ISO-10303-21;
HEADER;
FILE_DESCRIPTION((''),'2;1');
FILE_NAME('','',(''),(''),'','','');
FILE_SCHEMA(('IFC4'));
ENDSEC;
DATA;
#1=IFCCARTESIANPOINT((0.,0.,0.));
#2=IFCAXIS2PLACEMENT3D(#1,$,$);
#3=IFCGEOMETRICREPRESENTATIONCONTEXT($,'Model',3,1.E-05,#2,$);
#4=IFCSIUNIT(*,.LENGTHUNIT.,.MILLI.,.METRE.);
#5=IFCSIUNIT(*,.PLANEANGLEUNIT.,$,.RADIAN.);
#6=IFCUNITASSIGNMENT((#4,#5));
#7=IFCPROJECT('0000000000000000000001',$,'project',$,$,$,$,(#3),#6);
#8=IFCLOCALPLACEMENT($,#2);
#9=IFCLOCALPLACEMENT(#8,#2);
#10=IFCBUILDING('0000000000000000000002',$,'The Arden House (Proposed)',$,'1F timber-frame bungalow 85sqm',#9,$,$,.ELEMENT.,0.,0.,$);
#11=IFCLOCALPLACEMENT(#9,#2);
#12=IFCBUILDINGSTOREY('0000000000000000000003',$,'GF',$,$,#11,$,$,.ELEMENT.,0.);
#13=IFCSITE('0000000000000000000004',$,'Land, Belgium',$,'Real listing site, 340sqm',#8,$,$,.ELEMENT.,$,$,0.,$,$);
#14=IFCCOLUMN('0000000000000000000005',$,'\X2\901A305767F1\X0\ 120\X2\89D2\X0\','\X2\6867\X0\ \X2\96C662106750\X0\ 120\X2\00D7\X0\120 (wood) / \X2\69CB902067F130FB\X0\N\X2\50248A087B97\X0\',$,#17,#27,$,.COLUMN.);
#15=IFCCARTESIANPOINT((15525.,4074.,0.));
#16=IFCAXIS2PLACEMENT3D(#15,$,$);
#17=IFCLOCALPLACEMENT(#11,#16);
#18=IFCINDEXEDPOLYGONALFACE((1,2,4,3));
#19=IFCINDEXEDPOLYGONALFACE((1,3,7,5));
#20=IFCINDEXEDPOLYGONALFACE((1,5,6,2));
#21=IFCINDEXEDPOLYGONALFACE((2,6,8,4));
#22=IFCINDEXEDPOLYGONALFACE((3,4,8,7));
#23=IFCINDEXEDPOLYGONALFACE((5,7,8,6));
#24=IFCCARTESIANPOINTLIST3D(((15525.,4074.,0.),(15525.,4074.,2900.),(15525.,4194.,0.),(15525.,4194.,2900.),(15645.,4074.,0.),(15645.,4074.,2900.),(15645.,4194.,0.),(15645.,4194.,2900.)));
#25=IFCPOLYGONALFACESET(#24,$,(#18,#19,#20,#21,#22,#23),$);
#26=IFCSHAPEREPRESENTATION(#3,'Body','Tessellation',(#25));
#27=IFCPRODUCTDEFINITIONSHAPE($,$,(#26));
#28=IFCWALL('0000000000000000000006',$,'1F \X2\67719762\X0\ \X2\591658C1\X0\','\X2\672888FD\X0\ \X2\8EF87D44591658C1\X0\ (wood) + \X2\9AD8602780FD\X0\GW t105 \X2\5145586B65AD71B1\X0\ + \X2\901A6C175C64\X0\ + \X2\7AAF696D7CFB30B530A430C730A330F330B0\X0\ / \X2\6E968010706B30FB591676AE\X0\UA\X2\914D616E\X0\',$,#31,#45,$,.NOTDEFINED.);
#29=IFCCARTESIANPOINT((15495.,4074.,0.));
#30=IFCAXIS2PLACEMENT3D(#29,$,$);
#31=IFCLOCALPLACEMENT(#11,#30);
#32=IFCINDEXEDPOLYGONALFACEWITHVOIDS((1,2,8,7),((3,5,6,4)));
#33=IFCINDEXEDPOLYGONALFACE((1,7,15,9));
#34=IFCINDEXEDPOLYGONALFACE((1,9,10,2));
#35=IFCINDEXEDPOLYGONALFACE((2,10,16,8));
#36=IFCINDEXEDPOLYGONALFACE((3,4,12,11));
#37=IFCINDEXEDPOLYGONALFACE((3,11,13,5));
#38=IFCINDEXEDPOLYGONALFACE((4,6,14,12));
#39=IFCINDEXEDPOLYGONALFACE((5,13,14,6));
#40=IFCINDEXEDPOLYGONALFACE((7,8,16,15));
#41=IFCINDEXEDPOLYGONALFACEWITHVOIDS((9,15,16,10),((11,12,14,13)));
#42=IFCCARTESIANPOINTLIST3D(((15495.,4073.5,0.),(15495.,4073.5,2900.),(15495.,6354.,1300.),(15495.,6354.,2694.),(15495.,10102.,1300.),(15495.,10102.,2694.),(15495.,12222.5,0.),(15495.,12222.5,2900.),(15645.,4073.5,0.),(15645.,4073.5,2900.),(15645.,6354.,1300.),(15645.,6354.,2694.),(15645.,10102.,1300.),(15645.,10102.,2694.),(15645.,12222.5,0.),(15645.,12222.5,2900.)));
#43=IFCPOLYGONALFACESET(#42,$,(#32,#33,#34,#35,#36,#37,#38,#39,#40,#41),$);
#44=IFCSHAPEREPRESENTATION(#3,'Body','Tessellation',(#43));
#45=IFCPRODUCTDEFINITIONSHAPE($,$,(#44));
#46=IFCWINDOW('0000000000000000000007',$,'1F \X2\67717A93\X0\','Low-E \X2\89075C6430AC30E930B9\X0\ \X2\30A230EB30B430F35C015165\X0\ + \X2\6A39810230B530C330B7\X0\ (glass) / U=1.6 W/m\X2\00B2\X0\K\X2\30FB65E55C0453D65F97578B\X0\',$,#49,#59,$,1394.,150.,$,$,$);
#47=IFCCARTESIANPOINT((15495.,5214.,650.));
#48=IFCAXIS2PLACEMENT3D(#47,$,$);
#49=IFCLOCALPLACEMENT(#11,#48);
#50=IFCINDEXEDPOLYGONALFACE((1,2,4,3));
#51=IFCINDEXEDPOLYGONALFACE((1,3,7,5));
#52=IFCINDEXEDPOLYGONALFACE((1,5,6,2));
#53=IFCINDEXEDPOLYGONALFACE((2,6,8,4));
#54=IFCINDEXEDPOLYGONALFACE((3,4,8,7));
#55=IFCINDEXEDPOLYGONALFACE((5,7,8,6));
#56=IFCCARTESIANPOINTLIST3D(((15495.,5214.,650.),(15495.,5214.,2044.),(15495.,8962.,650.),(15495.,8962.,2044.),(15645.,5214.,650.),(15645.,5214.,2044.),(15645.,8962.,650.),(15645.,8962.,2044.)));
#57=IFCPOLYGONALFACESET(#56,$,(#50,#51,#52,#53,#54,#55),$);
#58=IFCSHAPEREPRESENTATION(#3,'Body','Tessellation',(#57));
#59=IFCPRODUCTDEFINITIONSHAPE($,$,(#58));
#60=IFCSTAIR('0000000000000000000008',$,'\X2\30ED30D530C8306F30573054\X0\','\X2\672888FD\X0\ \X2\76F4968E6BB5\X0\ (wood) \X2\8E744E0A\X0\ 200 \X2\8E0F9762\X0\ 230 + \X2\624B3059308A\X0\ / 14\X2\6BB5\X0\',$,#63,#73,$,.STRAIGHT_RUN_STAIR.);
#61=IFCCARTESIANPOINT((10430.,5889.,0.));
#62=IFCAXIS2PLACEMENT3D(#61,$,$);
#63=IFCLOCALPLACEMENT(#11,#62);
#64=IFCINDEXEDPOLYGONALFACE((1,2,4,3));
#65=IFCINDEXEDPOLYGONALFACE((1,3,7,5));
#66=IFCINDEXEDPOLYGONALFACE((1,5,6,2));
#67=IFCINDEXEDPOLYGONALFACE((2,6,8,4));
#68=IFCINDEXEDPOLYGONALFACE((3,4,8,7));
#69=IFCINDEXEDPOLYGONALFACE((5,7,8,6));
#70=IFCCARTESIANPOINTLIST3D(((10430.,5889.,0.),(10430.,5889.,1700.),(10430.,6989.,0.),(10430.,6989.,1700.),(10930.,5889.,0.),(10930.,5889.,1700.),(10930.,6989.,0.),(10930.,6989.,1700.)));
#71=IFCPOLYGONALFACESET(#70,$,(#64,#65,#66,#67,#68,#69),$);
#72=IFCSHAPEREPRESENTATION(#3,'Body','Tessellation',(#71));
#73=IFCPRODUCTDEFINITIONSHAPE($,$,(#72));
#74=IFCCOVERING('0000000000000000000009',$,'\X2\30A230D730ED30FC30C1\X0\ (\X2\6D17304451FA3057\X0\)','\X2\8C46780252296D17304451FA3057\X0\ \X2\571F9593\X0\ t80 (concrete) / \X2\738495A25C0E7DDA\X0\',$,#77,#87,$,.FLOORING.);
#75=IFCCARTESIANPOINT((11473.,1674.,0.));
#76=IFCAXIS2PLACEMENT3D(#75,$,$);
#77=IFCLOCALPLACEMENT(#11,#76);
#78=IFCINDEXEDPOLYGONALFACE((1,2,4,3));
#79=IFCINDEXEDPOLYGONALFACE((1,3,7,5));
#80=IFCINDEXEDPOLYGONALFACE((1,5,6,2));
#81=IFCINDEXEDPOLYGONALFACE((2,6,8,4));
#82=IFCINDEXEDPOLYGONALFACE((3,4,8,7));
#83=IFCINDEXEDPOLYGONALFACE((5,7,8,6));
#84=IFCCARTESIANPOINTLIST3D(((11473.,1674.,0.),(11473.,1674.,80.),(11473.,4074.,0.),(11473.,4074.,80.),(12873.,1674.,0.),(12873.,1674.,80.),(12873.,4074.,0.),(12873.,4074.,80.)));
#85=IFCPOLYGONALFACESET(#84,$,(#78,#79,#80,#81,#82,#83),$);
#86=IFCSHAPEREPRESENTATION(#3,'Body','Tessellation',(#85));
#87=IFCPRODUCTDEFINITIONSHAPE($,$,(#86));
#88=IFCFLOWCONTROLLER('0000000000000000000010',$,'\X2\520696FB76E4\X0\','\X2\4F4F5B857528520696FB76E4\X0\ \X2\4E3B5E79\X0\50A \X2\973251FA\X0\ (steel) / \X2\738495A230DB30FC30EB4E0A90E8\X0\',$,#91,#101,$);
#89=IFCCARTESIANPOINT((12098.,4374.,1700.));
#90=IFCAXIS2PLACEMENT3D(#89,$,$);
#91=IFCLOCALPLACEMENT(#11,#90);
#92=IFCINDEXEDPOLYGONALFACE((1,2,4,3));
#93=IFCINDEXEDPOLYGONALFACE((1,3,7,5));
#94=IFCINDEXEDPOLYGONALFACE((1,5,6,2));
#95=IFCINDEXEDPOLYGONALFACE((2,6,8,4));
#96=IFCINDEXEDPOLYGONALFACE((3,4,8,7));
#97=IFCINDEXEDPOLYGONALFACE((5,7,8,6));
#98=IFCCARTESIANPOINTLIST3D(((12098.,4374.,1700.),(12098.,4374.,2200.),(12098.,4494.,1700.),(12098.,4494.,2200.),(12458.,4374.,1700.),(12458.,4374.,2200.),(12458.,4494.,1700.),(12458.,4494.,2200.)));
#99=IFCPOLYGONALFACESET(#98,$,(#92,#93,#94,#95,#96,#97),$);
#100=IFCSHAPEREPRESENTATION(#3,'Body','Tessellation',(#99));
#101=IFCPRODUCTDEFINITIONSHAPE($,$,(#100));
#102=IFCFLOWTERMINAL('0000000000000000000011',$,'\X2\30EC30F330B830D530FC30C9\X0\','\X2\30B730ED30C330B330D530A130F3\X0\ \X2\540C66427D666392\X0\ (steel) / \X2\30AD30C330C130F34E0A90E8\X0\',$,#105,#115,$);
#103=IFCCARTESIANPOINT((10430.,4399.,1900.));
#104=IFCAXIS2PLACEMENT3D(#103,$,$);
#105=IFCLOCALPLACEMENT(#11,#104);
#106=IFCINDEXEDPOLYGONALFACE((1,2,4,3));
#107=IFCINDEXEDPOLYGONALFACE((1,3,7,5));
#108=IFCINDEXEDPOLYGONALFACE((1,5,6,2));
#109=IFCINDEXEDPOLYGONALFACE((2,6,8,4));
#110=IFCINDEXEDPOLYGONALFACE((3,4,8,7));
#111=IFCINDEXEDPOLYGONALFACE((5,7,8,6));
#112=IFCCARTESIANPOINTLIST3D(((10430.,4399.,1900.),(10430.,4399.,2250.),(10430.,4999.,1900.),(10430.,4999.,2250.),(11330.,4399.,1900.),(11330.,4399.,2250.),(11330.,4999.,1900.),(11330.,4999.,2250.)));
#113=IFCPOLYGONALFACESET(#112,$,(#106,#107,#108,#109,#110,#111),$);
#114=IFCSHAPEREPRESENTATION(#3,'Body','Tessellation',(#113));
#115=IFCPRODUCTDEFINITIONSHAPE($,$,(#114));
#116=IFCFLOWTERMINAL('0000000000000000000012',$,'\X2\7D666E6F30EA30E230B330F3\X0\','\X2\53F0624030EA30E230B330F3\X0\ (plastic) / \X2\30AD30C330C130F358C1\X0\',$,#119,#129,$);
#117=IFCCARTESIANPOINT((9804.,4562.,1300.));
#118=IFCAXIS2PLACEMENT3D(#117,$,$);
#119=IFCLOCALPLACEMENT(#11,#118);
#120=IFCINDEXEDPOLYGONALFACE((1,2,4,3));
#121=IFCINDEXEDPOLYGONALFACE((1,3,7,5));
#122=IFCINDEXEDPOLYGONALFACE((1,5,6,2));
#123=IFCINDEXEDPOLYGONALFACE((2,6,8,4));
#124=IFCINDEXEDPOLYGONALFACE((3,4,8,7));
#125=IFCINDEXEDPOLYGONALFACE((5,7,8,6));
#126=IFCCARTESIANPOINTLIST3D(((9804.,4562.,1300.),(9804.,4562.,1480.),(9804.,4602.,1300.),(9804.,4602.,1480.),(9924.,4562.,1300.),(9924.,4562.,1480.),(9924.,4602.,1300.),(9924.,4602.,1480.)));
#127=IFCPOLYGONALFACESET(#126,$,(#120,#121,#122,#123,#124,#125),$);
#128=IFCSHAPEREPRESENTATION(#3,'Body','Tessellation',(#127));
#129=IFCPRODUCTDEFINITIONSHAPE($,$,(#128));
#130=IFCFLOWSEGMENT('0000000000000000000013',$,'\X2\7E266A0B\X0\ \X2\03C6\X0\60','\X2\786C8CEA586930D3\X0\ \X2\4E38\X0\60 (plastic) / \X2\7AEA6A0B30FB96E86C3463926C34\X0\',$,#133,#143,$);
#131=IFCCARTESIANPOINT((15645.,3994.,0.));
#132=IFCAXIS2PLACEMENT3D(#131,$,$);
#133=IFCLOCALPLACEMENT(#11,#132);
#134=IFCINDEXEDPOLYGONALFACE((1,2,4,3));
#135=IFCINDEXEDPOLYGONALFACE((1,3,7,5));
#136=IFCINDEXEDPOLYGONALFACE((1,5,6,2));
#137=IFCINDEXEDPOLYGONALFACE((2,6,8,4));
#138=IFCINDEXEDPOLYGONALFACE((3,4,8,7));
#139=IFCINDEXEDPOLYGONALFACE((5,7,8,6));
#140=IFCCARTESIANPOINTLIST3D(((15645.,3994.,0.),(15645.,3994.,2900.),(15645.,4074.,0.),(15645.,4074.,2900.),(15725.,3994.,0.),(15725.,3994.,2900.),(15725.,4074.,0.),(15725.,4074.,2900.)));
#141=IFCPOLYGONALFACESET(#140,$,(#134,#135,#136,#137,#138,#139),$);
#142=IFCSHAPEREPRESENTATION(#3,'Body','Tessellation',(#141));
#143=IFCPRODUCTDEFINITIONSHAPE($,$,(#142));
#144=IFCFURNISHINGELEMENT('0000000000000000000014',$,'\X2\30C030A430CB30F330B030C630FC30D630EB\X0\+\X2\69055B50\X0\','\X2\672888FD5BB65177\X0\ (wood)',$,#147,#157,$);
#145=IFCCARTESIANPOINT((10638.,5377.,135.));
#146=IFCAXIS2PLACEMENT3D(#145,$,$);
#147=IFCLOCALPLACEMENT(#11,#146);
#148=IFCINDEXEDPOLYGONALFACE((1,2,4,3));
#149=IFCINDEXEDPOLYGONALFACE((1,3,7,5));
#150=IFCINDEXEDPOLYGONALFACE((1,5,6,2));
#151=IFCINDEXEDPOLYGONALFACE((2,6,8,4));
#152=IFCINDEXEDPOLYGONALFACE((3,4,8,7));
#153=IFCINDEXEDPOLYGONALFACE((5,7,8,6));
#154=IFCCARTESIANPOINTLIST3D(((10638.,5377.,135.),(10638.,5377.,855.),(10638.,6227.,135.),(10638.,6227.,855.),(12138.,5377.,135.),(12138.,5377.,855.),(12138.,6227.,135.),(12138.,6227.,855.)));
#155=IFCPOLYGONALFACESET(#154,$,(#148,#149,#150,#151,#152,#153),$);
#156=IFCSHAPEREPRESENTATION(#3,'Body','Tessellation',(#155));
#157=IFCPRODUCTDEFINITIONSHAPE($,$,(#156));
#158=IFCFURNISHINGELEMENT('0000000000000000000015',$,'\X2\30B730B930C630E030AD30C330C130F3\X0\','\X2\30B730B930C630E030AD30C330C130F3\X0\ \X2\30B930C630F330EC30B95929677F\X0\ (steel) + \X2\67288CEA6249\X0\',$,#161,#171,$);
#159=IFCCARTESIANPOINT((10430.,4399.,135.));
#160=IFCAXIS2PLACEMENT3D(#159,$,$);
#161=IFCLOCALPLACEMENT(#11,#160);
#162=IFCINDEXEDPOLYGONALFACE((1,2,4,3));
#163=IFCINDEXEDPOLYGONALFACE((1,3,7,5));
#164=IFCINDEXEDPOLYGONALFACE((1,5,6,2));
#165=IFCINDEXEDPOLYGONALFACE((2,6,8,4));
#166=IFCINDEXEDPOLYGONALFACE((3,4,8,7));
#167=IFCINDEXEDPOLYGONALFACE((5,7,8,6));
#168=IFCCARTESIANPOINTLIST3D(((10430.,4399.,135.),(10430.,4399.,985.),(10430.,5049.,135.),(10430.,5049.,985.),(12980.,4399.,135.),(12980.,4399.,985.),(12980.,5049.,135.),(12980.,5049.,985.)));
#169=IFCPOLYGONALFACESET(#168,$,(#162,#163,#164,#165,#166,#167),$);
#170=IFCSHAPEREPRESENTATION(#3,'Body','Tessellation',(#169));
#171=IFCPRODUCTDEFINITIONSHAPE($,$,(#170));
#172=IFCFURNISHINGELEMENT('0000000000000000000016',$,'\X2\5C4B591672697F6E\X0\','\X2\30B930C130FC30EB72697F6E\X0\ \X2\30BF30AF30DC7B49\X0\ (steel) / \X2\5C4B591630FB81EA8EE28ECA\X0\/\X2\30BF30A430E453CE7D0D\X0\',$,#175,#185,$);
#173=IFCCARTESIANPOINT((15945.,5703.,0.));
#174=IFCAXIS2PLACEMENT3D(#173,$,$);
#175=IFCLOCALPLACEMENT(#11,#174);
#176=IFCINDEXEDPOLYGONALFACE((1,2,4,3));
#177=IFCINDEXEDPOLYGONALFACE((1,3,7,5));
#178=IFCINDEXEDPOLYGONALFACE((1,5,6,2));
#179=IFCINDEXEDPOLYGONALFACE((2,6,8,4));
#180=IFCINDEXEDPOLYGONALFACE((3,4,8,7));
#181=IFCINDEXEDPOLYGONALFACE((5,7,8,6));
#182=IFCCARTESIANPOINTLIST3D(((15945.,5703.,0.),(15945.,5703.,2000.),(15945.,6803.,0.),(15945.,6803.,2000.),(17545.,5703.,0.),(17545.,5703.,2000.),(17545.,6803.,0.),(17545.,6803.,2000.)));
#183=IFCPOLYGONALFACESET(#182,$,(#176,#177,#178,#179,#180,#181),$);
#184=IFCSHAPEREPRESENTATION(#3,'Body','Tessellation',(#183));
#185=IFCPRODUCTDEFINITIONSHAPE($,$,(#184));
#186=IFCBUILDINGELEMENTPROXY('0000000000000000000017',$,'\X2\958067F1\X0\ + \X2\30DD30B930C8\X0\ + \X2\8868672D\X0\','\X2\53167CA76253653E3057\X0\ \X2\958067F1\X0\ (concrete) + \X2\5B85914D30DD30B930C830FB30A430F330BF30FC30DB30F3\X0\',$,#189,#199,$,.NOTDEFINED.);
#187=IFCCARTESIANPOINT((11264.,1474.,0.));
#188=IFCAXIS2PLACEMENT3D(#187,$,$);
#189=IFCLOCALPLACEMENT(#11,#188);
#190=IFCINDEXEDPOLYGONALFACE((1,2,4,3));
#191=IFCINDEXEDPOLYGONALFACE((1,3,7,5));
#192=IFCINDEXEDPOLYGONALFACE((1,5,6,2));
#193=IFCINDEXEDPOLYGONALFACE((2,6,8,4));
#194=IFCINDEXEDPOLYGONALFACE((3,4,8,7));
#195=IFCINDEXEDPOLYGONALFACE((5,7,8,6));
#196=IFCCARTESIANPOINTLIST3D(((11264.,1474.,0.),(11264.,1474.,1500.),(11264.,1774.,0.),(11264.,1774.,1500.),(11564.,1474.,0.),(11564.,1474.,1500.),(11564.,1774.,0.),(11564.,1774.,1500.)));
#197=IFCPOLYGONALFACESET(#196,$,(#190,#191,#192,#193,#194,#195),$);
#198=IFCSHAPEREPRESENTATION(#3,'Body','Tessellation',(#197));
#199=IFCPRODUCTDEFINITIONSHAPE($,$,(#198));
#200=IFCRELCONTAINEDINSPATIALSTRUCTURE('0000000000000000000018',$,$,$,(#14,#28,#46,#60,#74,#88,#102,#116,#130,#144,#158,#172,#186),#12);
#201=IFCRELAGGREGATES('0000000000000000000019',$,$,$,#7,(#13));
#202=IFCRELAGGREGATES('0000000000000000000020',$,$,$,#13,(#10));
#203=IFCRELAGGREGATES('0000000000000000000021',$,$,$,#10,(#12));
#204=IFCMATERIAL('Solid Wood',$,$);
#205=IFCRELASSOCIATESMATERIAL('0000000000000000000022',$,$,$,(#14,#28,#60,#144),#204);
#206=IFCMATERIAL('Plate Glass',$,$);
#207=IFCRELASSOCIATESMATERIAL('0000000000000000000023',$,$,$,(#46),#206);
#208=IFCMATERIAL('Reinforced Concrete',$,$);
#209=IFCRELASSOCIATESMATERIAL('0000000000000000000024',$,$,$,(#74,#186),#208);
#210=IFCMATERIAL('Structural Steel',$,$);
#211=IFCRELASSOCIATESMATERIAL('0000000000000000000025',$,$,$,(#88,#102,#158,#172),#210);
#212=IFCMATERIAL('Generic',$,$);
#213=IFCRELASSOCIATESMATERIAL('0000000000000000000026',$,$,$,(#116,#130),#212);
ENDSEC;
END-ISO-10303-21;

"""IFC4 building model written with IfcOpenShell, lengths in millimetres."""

from ifc_helpers import new_model, si_unit, frame, frame_2d, origin, place, context, project, spatial, rectangle, extrude, material, element, fill, save


model = new_model("IFC4")

# Units and contexts
model_context = context("Model", 3, precision=1e-05, world=origin())
ifc_project = project(units=[si_unit("LENGTHUNIT", "METRE", prefix="MILLI"), si_unit("PLANEANGLEUNIT", "RADIAN")], contexts=[model_context])

# Site, building, storey
site_placement = place(None, origin())
site = spatial("IfcSite", under=ifc_project, at=site_placement, Name="Land, Belgium", ObjectType="Real listing site, 340sqm", CompositionType="ELEMENT", RefElevation=0.0)
building_placement = place(site_placement, origin())
building = spatial("IfcBuilding", under=site, at=building_placement, Name="The Arden House (Proposed)", ObjectType="1F timber-frame bungalow 85sqm", CompositionType="ELEMENT", ElevationOfRefHeight=0.0, ElevationOfTerrain=0.0)
storey_placement = place(building_placement, origin())
storey = spatial("IfcBuildingStorey", under=building, at=storey_placement, Name="GF", CompositionType="ELEMENT", Elevation=0.0)

# Column
ifc_material_1 = material(Name="Solid Wood")
column_1_placement = place(storey_placement, frame((15525.0, 4074.0, 0.0)))
element("IfcColumn", 1, at=column_1_placement, inside=storey, material=ifc_material_1, Name="通し柱 120角", Description="桧 集成材 120×120 (wood) / 構造柱・N値計算", PredefinedType="COLUMN", context=model_context, shape_type="SweptSolid", body=[
    extrude(rectangle(XDim=120.0, YDim=120.0, at=frame_2d((60.0, 60.0))), frame((15525.0, 4074.0, 0.0)), (0.0, 0.0, 1.0), 2900.0),
])

# Wall, opening, window
wall_1_placement = place(storey_placement, frame((15495.0, 4074.0, 0.0)))
wall_1 = element("IfcWall", 2, at=wall_1_placement, inside=storey, material=ifc_material_1, Name="1F 東面 外壁", Description="木製 軸組外壁 (wood) + 高性能GW t105 充填断熱 + 通気層 + 窯業系サイディング / 準耐火・外皮UA配慮", PredefinedType="NOTDEFINED", context=model_context, shape_type="SweptSolid", body=[
    extrude(rectangle(XDim=150.0, YDim=8149.0, at=frame_2d((75.0, 4074.0))), frame((15495.0, 4074.0, 0.0)), (0.0, 0.0, 1.0), 2900.0),
])
opening_placement = place(storey_placement, frame((15495.0, 5214.0, 650.0)))
opening = element("IfcOpeningElement", 3, at=opening_placement, cuts=wall_1, PredefinedType="NOTDEFINED", context=model_context, shape_type="SweptSolid", body=[
    extrude(rectangle(XDim=150.0, YDim=3748.0, at=frame_2d((75.0, 1874.0))), frame((15495.0, 5214.0, 650.0)), (0.0, 0.0, 1.0), 1394.0),
])
ifc_material_2 = material(Name="Plate Glass")
window_placement = place(storey_placement, frame((15495.0, 5214.0, 650.0)))
window = element("IfcWindow", 4, at=window_placement, inside=storey, material=ifc_material_2, Name="1F 東窓", Description="Low-E 複層ガラス アルゴン封入 + 樹脂サッシ (glass) / U=1.6 W/m²K・日射取得型", OverallHeight=1394.0, OverallWidth=150.0, context=model_context, shape_type="SweptSolid", body=[
    extrude(rectangle(XDim=150.0, YDim=3748.0, at=frame_2d((75.0, 1874.0))), frame((15495.0, 5214.0, 650.0)), (0.0, 0.0, 1.0), 1394.0),
])
fill(opening, window)

# Stair
stair_placement = place(storey_placement, frame((10430.0, 5889.0, 0.0)))
element("IfcStair", 5, at=stair_placement, inside=storey, material=ifc_material_1, Name="ロフトはしご", Description="木製 直階段 (wood) 蹴上 200 踏面 230 + 手すり / 14段", PredefinedType="STRAIGHT_RUN_STAIR", context=model_context, shape_type="SweptSolid", body=[
    extrude(rectangle(XDim=500.0, YDim=1100.0, at=frame_2d((250.0, 550.0))), frame((10430.0, 5889.0, 0.0)), (0.0, 0.0, 1.0), 1700.0),
])

# Covering
ifc_material_3 = material(Name="Reinforced Concrete")
covering_placement = place(storey_placement, frame((11473.0, 1674.0, 0.0)))
element("IfcCovering", 6, at=covering_placement, inside=storey, material=ifc_material_3, Name="アプローチ (洗い出し)", Description="豆砂利洗い出し 土間 t80 (concrete) / 玄関導線", PredefinedType="FLOORING", context=model_context, shape_type="SweptSolid", body=[
    extrude(rectangle(XDim=1400.0, YDim=2400.0, at=frame_2d((700.0, 1200.0))), frame((11473.0, 1674.0, 0.0)), (0.0, 0.0, 1.0), 80.0),
])

# Flow controller
ifc_material_4 = material(Name="Structural Steel")
flow_controller_placement = place(storey_placement, frame((12098.0, 4374.0, 1700.0)))
element("IfcFlowController", 7, at=flow_controller_placement, inside=storey, material=ifc_material_4, Name="分電盤", Description="住宅用分電盤 主幹50A 露出 (steel) / 玄関ホール上部", context=model_context, shape_type="SweptSolid", body=[
    extrude(rectangle(XDim=360.0, YDim=120.0, at=frame_2d((180.0, 60.0))), frame((12098.0, 4374.0, 1700.0)), (0.0, 0.0, 1.0), 500.0),
])

# Flow terminals
flow_terminal_1_placement = place(storey_placement, frame((10430.0, 4399.0, 1900.0)))
element("IfcFlowTerminal", 8, at=flow_terminal_1_placement, inside=storey, material=ifc_material_4, Name="レンジフード", Description="シロッコファン 同時給排 (steel) / キッチン上部", context=model_context, shape_type="SweptSolid", body=[
    extrude(rectangle(XDim=900.0, YDim=600.0, at=frame_2d((450.0, 300.0))), frame((10430.0, 4399.0, 1900.0)), (0.0, 0.0, 1.0), 350.0),
])
ifc_material_5 = material(Name="Generic")
flow_terminal_2_placement = place(storey_placement, frame((9804.0, 4562.0, 1300.0)))
element("IfcFlowTerminal", 9, at=flow_terminal_2_placement, inside=storey, material=ifc_material_5, Name="給湯リモコン", Description="台所リモコン (plastic) / キッチン壁", context=model_context, shape_type="SweptSolid", body=[
    extrude(rectangle(XDim=120.0, YDim=40.0, at=frame_2d((60.0, 20.0))), frame((9804.0, 4562.0, 1300.0)), (0.0, 0.0, 1.0), 180.0),
])

# Flow segment
flow_segment_placement = place(storey_placement, frame((15645.0, 3994.0, 0.0)))
element("IfcFlowSegment", 10, at=flow_segment_placement, inside=storey, material=ifc_material_5, Name="縦樋 φ60", Description="硬質塩ビ 丸60 (plastic) / 竪樋・雨水排水", context=model_context, shape_type="SweptSolid", body=[
    extrude(rectangle(XDim=80.0, YDim=80.0, at=frame_2d((40.0, 40.0))), frame((15645.0, 3994.0, 0.0)), (0.0, 0.0, 1.0), 2900.0),
])

# Furnishing elements
furnishing_1_placement = place(storey_placement, frame((10638.0, 5377.0, 135.0)))
element("IfcFurnishingElement", 11, at=furnishing_1_placement, inside=storey, material=ifc_material_1, Name="ダイニングテーブル+椅子", Description="木製家具 (wood)", context=model_context, shape_type="SweptSolid", body=[
    extrude(rectangle(XDim=1500.0, YDim=850.0, at=frame_2d((750.0, 425.0))), frame((10638.0, 5377.0, 135.0)), (0.0, 0.0, 1.0), 720.0),
])
furnishing_2_placement = place(storey_placement, frame((10430.0, 4399.0, 135.0)))
element("IfcFurnishingElement", 12, at=furnishing_2_placement, inside=storey, material=ifc_material_4, Name="システムキッチン", Description="システムキッチン ステンレス天板 (steel) + 木質扉", context=model_context, shape_type="SweptSolid", body=[
    extrude(rectangle(XDim=2550.0, YDim=650.0, at=frame_2d((1275.0, 325.0))), frame((10430.0, 4399.0, 135.0)), (0.0, 0.0, 1.0), 850.0),
])
furnishing_3_placement = place(storey_placement, frame((15945.0, 5703.0, 0.0)))
element("IfcFurnishingElement", 13, at=furnishing_3_placement, inside=storey, material=ifc_material_4, Name="屋外物置", Description="スチール物置 タクボ等 (steel) / 屋外・自転車/タイヤ収納", context=model_context, shape_type="SweptSolid", body=[
    extrude(rectangle(XDim=1600.0, YDim=1100.0, at=frame_2d((800.0, 550.0))), frame((15945.0, 5703.0, 0.0)), (0.0, 0.0, 1.0), 2000.0),
])

# Building element proxy
proxy_placement = place(storey_placement, frame((11264.0, 1474.0, 0.0)))
element("IfcBuildingElementProxy", 14, at=proxy_placement, inside=storey, material=ifc_material_3, Name="門柱 + ポスト + 表札", Description="化粧打放し 門柱 (concrete) + 宅配ポスト・インターホン", PredefinedType="NOTDEFINED", context=model_context, shape_type="SweptSolid", body=[
    extrude(rectangle(XDim=300.0, YDim=300.0, at=frame_2d((150.0, 150.0))), frame((11264.0, 1474.0, 0.0)), (0.0, 0.0, 1.0), 1500.0),
])

save(model, "model.ifc")
